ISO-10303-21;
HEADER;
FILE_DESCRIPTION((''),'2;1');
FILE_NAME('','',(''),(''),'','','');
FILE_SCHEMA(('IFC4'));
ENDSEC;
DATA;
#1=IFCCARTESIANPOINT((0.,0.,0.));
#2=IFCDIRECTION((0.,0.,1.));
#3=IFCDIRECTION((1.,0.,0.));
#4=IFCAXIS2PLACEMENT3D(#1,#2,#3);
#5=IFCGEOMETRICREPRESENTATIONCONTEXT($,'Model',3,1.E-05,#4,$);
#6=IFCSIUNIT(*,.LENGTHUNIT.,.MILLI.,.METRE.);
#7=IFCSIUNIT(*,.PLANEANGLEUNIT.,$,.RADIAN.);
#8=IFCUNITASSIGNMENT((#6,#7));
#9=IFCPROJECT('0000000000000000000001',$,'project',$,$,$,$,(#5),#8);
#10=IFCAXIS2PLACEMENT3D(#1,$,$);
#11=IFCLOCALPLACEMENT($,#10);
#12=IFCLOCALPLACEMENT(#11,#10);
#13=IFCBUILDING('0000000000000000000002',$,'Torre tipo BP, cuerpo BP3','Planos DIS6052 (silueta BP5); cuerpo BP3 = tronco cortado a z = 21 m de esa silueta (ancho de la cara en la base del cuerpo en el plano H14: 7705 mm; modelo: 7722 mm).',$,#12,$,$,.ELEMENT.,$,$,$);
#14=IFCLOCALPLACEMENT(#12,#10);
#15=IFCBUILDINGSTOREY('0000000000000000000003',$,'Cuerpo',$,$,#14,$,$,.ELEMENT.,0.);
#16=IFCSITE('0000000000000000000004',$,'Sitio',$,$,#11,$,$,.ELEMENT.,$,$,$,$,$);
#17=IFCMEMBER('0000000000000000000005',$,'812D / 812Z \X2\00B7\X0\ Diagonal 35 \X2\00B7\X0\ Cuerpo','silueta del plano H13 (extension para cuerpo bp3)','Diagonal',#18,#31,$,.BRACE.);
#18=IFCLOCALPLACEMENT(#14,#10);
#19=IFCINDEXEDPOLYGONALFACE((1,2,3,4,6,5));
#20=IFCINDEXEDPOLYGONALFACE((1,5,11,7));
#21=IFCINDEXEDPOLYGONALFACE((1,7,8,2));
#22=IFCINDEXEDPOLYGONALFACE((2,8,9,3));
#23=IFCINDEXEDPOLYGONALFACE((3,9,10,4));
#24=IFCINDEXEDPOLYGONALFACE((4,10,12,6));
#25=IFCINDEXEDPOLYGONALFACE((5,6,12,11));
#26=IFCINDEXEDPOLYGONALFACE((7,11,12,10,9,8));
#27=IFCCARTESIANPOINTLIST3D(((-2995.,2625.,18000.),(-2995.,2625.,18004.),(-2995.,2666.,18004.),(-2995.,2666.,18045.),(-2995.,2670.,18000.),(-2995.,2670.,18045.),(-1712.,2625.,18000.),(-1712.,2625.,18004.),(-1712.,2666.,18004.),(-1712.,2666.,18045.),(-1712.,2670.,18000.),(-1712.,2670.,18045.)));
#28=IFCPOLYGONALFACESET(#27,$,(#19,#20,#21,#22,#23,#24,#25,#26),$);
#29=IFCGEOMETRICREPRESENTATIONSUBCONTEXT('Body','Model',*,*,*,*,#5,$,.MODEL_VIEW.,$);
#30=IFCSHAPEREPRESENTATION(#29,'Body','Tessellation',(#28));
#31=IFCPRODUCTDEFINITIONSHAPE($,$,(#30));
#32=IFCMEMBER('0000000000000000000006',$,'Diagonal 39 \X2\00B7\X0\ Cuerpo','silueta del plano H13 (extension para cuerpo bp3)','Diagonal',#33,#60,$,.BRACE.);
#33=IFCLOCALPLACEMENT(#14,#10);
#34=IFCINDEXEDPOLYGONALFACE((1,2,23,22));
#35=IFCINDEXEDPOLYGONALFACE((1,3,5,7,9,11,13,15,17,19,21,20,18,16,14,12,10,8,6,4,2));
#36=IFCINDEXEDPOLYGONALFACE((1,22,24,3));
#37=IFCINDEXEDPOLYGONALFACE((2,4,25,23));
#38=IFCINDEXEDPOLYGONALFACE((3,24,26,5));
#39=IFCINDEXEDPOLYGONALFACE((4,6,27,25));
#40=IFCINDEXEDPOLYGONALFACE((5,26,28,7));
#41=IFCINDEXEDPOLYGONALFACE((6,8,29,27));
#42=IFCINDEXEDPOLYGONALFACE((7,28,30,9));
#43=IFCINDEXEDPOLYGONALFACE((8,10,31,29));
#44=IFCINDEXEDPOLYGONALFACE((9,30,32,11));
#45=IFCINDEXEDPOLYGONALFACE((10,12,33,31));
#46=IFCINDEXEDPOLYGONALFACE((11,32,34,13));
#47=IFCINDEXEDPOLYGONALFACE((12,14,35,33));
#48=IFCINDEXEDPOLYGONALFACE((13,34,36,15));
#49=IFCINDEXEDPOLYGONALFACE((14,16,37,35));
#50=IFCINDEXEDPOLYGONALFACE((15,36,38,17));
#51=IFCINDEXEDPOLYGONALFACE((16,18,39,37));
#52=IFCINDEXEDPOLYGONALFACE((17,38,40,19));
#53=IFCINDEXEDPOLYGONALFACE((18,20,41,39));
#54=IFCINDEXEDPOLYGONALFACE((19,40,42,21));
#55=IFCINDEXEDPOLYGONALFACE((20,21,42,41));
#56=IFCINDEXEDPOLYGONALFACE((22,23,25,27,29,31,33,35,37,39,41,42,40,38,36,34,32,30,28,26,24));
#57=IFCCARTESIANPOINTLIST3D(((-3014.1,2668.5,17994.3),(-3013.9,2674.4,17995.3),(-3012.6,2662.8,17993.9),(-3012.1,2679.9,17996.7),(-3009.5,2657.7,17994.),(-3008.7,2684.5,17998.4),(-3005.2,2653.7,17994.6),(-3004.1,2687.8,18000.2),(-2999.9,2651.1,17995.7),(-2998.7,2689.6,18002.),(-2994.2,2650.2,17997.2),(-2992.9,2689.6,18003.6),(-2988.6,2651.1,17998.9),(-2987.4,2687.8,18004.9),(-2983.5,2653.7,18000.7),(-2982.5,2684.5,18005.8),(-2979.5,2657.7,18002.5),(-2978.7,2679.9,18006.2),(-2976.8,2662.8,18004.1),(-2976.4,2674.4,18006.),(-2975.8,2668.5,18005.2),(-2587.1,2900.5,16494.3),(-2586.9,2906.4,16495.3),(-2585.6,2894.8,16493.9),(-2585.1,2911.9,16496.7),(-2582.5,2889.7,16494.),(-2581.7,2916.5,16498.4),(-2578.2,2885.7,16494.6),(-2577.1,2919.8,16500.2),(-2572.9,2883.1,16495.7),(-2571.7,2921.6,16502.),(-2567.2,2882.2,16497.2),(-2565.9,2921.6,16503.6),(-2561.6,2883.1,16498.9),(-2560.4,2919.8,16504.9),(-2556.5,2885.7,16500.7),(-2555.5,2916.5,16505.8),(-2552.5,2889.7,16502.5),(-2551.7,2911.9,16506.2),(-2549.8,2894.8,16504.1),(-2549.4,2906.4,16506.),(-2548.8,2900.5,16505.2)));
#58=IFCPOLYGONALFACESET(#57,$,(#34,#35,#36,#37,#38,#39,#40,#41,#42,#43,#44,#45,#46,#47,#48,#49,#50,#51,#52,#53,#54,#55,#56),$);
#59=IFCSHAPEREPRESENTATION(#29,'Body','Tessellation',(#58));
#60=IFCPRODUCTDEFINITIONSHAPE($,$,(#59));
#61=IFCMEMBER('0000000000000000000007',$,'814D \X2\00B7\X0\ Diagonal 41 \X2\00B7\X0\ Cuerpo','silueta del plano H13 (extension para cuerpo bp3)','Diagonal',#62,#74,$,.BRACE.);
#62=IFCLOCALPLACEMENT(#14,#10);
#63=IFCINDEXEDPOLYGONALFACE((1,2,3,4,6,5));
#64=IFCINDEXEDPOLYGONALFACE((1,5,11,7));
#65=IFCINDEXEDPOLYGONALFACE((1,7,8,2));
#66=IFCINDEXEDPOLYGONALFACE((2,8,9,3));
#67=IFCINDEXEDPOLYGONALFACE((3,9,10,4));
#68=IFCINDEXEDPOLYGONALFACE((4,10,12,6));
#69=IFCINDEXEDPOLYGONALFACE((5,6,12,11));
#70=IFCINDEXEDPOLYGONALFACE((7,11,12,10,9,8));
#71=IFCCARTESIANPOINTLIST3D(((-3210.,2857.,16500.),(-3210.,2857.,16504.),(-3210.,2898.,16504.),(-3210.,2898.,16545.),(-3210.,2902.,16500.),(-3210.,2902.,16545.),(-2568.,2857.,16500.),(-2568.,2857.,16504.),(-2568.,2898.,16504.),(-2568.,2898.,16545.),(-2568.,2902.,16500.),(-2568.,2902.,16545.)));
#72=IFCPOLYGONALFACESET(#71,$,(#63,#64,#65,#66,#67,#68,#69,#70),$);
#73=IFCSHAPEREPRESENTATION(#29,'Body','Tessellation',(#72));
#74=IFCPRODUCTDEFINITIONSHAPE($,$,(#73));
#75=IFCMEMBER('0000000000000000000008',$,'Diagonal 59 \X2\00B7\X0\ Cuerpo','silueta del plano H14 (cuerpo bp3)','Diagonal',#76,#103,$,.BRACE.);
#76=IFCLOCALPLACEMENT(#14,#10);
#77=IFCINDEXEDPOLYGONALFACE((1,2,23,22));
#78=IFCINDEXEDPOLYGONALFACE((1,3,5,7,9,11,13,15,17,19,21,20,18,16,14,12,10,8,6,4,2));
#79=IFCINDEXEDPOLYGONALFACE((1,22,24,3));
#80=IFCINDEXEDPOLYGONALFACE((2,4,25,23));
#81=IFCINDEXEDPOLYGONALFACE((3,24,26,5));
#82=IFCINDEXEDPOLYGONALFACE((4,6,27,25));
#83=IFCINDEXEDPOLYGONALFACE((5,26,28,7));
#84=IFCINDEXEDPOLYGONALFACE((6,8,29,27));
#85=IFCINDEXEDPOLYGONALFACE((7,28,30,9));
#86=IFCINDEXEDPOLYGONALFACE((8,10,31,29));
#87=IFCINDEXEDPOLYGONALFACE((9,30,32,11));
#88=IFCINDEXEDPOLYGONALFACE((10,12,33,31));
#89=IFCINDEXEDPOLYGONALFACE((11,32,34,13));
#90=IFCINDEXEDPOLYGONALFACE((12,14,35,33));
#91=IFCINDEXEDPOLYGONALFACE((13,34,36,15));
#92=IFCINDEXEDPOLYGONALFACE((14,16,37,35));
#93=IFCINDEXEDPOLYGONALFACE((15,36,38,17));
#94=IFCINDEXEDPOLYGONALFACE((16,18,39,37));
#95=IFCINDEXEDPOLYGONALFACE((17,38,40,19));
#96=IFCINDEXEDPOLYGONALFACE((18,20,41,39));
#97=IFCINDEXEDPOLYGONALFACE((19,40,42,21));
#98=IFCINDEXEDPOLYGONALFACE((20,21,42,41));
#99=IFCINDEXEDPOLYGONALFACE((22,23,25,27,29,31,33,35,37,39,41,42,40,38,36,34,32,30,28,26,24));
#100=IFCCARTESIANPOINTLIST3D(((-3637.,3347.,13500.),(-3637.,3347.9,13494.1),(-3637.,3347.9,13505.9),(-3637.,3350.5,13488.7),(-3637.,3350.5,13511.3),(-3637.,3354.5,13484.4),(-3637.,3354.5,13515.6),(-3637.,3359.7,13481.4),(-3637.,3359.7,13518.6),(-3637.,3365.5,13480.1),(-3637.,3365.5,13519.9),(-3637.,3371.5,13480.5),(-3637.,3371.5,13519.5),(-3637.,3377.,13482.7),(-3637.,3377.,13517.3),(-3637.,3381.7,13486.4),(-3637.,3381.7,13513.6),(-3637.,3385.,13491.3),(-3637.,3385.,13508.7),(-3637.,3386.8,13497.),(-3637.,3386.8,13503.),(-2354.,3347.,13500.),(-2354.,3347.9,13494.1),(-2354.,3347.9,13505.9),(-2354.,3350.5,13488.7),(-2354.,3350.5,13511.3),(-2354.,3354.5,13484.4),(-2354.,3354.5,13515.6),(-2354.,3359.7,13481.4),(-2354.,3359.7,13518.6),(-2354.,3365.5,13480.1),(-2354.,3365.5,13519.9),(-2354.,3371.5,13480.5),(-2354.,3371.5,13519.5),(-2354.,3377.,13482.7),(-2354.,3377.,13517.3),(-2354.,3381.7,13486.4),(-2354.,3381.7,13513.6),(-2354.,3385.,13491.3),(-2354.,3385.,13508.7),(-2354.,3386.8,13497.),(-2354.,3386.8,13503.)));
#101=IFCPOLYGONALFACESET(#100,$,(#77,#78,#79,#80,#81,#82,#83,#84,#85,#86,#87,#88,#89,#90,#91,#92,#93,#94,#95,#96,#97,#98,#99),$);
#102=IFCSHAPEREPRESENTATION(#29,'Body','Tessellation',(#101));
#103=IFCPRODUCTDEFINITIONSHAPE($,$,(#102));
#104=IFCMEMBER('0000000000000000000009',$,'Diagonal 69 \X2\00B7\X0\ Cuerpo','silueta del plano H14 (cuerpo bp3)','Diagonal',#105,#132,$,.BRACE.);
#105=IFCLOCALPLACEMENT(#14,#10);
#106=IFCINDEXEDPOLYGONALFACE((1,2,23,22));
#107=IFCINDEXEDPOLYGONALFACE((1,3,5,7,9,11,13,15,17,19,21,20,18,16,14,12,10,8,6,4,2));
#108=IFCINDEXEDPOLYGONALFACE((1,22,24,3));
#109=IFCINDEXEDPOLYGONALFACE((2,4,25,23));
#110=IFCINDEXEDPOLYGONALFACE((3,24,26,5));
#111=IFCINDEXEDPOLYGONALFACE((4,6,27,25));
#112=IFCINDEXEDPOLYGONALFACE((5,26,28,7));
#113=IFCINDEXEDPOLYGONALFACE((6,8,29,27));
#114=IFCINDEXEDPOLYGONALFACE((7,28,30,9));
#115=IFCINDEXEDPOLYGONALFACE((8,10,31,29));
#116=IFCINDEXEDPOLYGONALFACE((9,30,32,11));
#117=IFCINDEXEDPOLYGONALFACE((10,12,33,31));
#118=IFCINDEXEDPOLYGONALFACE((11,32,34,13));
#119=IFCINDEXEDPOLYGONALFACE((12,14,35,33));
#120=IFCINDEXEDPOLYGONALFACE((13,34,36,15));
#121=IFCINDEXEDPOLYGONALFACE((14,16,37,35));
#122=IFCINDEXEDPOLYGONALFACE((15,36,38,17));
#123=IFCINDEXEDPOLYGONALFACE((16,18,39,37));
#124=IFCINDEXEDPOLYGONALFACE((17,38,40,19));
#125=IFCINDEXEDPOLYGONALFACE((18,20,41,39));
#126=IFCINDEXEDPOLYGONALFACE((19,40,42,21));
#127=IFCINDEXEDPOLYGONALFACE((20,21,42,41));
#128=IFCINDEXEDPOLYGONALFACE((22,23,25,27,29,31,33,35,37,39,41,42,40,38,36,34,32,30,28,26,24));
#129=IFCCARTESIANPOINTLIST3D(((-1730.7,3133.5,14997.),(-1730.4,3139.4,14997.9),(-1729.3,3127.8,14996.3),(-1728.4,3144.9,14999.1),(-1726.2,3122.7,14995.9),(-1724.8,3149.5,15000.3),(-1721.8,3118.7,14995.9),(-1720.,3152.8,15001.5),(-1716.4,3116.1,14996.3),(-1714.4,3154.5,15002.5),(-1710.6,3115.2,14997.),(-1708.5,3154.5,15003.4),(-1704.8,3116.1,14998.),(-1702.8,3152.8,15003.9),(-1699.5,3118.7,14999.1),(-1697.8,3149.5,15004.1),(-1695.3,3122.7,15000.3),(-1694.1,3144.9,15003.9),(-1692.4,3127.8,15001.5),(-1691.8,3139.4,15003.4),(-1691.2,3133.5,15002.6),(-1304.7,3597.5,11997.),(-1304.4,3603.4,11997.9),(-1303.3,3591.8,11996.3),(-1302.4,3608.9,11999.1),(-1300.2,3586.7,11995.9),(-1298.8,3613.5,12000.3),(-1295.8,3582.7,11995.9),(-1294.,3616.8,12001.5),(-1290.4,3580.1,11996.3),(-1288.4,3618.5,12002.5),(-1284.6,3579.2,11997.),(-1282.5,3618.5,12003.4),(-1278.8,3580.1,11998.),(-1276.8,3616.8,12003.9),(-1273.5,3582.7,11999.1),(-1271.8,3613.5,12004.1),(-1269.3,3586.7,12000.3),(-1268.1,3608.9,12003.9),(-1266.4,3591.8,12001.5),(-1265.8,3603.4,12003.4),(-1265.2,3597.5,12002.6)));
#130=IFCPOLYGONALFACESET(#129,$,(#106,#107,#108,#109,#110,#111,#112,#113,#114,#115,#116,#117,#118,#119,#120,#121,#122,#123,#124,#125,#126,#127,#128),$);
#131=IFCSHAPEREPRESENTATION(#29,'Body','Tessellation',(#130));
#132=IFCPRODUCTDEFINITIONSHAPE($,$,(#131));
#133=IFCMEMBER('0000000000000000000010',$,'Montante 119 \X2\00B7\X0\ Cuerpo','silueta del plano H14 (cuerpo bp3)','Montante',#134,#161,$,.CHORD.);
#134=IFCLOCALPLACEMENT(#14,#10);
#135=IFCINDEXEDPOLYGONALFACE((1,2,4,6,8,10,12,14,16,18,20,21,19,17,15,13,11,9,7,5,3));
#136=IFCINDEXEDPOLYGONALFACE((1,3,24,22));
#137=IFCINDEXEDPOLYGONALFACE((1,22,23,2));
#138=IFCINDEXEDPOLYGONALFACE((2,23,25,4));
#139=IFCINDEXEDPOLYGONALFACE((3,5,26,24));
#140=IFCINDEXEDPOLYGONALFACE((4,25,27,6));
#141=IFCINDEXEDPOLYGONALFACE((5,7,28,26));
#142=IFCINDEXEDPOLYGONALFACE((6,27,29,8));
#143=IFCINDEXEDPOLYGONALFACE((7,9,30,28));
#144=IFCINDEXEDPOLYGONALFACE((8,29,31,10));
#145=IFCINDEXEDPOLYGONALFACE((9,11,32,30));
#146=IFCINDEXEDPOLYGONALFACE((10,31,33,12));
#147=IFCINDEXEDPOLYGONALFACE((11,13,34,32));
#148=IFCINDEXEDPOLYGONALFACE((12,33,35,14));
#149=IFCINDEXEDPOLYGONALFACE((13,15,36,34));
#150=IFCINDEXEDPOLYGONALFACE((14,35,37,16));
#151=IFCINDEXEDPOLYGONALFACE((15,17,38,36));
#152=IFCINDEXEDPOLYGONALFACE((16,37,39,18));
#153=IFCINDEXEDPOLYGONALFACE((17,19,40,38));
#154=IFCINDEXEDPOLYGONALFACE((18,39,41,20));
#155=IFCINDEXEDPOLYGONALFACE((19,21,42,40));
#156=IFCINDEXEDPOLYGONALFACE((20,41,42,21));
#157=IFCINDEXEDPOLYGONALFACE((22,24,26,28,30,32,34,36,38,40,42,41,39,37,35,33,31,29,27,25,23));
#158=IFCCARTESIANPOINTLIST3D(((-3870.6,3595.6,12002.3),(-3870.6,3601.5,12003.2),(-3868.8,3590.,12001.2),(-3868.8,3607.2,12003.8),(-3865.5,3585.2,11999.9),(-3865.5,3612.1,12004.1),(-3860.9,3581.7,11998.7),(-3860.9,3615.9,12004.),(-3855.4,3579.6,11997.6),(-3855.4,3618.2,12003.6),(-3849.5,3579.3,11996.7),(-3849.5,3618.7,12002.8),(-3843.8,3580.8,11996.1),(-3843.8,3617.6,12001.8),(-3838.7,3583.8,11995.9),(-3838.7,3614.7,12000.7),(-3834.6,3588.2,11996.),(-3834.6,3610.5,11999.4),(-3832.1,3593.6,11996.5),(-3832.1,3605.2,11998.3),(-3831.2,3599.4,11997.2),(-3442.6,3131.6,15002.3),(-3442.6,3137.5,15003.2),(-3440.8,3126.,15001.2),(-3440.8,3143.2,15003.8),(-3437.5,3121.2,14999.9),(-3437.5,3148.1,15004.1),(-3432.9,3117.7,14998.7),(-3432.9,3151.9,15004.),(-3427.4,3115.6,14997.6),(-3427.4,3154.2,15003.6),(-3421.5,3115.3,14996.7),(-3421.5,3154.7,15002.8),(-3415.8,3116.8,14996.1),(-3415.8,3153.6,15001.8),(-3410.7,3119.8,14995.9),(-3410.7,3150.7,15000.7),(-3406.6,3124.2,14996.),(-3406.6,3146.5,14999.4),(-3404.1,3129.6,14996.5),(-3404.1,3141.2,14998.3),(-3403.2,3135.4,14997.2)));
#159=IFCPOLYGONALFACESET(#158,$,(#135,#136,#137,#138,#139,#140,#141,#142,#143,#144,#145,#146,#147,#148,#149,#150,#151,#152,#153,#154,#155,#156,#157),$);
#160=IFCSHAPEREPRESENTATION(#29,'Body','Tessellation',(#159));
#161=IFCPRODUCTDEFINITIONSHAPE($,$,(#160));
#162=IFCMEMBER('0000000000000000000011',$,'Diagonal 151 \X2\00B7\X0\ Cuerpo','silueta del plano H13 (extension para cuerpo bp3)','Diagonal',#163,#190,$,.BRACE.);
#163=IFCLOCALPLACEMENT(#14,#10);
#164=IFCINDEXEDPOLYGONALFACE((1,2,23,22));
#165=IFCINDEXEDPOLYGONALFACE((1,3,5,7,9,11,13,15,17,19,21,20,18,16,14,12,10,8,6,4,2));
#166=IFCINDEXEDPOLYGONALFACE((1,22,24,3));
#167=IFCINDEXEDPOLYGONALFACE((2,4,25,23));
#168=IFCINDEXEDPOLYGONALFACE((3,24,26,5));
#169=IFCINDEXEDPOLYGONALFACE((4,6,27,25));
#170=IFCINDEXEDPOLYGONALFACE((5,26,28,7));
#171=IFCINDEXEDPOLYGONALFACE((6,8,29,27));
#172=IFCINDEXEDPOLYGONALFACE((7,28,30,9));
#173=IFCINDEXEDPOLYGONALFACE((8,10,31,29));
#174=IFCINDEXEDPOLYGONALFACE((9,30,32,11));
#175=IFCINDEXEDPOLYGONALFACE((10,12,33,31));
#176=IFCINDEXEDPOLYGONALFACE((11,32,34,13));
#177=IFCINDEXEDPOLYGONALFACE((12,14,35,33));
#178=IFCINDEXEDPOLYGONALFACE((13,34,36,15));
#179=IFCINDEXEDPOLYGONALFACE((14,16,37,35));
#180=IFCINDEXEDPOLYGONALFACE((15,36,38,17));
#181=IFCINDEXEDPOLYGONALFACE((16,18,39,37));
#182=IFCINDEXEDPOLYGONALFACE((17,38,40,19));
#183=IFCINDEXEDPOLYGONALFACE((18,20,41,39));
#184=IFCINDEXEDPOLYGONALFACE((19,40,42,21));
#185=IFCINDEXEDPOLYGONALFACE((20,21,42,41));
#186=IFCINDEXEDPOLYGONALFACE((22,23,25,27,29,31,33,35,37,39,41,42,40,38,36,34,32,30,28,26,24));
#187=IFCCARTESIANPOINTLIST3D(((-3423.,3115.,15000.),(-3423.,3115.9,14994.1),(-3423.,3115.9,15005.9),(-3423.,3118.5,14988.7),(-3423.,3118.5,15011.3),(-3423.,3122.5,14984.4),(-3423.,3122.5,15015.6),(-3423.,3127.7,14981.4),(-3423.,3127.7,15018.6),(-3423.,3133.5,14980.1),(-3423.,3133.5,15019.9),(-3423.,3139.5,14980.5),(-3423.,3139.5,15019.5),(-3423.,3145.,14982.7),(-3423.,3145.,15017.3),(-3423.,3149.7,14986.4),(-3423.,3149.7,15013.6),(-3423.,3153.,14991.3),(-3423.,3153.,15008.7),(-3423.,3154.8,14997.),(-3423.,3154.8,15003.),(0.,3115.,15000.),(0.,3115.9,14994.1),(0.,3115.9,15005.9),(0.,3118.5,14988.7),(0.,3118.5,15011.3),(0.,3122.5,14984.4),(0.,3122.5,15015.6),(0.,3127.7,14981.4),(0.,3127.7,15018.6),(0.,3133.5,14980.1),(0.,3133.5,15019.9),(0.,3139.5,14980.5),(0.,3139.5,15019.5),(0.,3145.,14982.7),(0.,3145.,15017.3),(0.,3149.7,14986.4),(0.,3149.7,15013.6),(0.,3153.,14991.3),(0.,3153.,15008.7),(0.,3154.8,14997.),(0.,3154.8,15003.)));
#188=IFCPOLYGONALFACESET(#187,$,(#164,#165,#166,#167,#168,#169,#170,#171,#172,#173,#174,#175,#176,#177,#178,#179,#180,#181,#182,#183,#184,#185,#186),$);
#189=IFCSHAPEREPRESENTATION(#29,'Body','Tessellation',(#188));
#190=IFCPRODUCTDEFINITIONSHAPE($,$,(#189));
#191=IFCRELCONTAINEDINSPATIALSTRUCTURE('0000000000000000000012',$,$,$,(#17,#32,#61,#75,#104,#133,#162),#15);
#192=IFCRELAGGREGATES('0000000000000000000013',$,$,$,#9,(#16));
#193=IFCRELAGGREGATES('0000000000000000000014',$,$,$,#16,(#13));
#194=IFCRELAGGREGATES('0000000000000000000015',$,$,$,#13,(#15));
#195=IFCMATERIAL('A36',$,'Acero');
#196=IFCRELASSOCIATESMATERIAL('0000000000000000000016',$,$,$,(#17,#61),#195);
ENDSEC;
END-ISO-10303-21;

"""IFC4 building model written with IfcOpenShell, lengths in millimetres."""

from ifc_helpers import new_model, si_unit, frame, frame_2d, origin, origin_with_axes, place, context, subcontext, project, spatial, circle, l_section, extrude, material, element, save


model = new_model("IFC4")

# Units and contexts
model_context = context("Model", 3, precision=1e-05, world=origin_with_axes())
body_context = subcontext(model_context, "Body", "Model", "MODEL_VIEW")
ifc_project = project(units=[si_unit("LENGTHUNIT", "METRE", prefix="MILLI"), si_unit("PLANEANGLEUNIT", "RADIAN")], contexts=[model_context])

# Site, building, storey
site_placement = place(None, origin())
site = spatial("IfcSite", under=ifc_project, at=site_placement, Name="Sitio", CompositionType="ELEMENT")
building_placement = place(site_placement, origin())
building = spatial("IfcBuilding", under=site, at=building_placement, Name="Torre tipo BP, cuerpo BP3", Description="Planos DIS6052 (silueta BP5); cuerpo BP3 = tronco cortado a z = 21 m de esa silueta (ancho de la cara en la base del cuerpo en el plano H14: 7705 mm; modelo: 7722 mm).", CompositionType="ELEMENT")
storey_placement = place(building_placement, origin())
storey = spatial("IfcBuildingStorey", under=building, at=storey_placement, Name="Cuerpo", CompositionType="ELEMENT", Elevation=0.0)

# Members
ifc_material = material(Name="A36", Category="Acero")
member_1_placement = place(storey_placement, frame((-1712.0, 2670.0, 18000.0), z_axis=(-1.0, 0.0, 0.0), x_axis=(0.0, -1.0, 0.0)))
element("IfcMember", 1, at=member_1_placement, inside=storey, material=ifc_material, Name="812D / 812Z · Diagonal 35 · Cuerpo", Description="silueta del plano H13 (extension para cuerpo bp3)", ObjectType="Diagonal", PredefinedType="BRACE", context=body_context, shape_type="SweptSolid", body=[
    extrude(l_section(Depth=45.0, Width=45.0, Thickness=4.0, at=frame_2d((22.5, 22.5))), None, (0.0, 0.0, 1.0), 1283.0),
])
member_2_placement = place(storey_placement, frame((-2568.0, 2902.0, 16500.0), z_axis=(-0.27081, -0.147138, 0.951322), x_axis=(0.040285, -0.989116, -0.141516)))
element("IfcMember", 2, at=member_2_placement, inside=storey, Name="Diagonal 39 · Cuerpo", Description="silueta del plano H13 (extension para cuerpo bp3)", ObjectType="Diagonal", PredefinedType="BRACE", context=body_context, shape_type="SweptSolid", body=[
    extrude(circle(Radius=20.0), None, (0.0, 0.0, 1.0), 1576.8),
])
member_3_placement = place(storey_placement, frame((-2568.0, 2902.0, 16500.0), z_axis=(-1.0, 0.0, 0.0), x_axis=(0.0, -1.0, 0.0)))
element("IfcMember", 3, at=member_3_placement, inside=storey, material=ifc_material, Name="814D · Diagonal 41 · Cuerpo", Description="silueta del plano H13 (extension para cuerpo bp3)", ObjectType="Diagonal", PredefinedType="BRACE", context=body_context, shape_type="SweptSolid", body=[
    extrude(l_section(Depth=45.0, Width=45.0, Thickness=4.0, at=frame_2d((22.5, 22.5))), None, (0.0, 0.0, 1.0), 642.0),
])
member_4_placement = place(storey_placement, frame((-2354.0, 3367.0, 13500.0), z_axis=(-1.0, 0.0, 0.0), x_axis=(0.0, -1.0, 0.0)))
element("IfcMember", 4, at=member_4_placement, inside=storey, Name="Diagonal 59 · Cuerpo", Description="silueta del plano H14 (cuerpo bp3)", ObjectType="Diagonal", PredefinedType="BRACE", context=body_context, shape_type="SweptSolid", body=[
    extrude(circle(Radius=20.0), None, (0.0, 0.0, 1.0), 1283.0),
])
member_5_placement = place(storey_placement, frame((-1711.0, 3135.0, 15000.0), z_axis=(0.13897, 0.151366, -0.97866), x_axis=(0.021281, -0.988478, -0.149863)))
element("IfcMember", 5, at=member_5_placement, inside=storey, Name="Diagonal 69 · Cuerpo", Description="silueta del plano H14 (cuerpo bp3)", ObjectType="Diagonal", PredefinedType="BRACE", context=body_context, shape_type="SweptSolid", body=[
    extrude(circle(Radius=20.0), None, (0.0, 0.0, 1.0), 3065.4),
])
member_6_placement = place(storey_placement, frame((-3423.0, 3135.0, 15000.0), z_axis=(-0.139609, 0.151352, -0.978571), x_axis=(0.990207, 0.021339, -0.137969)))
element("IfcMember", 6, at=member_6_placement, inside=storey, Name="Montante 119 · Cuerpo", Description="silueta del plano H14 (cuerpo bp3)", ObjectType="Montante", PredefinedType="CHORD", context=body_context, shape_type="SweptSolid", body=[
    extrude(circle(Radius=20.0), None, (0.0, 0.0, 1.0), 3065.7),
])
member_7_placement = place(storey_placement, frame((-3423.0, 3135.0, 15000.0), z_axis=(1.0, 0.0, 0.0), x_axis=(0.0, -1.0, 0.0)))
element("IfcMember", 7, at=member_7_placement, inside=storey, Name="Diagonal 151 · Cuerpo", Description="silueta del plano H13 (extension para cuerpo bp3)", ObjectType="Diagonal", PredefinedType="BRACE", context=body_context, shape_type="SweptSolid", body=[
    extrude(circle(Radius=20.0), None, (0.0, 0.0, 1.0), 3423.0),
])

save(model, "model.ifc")
